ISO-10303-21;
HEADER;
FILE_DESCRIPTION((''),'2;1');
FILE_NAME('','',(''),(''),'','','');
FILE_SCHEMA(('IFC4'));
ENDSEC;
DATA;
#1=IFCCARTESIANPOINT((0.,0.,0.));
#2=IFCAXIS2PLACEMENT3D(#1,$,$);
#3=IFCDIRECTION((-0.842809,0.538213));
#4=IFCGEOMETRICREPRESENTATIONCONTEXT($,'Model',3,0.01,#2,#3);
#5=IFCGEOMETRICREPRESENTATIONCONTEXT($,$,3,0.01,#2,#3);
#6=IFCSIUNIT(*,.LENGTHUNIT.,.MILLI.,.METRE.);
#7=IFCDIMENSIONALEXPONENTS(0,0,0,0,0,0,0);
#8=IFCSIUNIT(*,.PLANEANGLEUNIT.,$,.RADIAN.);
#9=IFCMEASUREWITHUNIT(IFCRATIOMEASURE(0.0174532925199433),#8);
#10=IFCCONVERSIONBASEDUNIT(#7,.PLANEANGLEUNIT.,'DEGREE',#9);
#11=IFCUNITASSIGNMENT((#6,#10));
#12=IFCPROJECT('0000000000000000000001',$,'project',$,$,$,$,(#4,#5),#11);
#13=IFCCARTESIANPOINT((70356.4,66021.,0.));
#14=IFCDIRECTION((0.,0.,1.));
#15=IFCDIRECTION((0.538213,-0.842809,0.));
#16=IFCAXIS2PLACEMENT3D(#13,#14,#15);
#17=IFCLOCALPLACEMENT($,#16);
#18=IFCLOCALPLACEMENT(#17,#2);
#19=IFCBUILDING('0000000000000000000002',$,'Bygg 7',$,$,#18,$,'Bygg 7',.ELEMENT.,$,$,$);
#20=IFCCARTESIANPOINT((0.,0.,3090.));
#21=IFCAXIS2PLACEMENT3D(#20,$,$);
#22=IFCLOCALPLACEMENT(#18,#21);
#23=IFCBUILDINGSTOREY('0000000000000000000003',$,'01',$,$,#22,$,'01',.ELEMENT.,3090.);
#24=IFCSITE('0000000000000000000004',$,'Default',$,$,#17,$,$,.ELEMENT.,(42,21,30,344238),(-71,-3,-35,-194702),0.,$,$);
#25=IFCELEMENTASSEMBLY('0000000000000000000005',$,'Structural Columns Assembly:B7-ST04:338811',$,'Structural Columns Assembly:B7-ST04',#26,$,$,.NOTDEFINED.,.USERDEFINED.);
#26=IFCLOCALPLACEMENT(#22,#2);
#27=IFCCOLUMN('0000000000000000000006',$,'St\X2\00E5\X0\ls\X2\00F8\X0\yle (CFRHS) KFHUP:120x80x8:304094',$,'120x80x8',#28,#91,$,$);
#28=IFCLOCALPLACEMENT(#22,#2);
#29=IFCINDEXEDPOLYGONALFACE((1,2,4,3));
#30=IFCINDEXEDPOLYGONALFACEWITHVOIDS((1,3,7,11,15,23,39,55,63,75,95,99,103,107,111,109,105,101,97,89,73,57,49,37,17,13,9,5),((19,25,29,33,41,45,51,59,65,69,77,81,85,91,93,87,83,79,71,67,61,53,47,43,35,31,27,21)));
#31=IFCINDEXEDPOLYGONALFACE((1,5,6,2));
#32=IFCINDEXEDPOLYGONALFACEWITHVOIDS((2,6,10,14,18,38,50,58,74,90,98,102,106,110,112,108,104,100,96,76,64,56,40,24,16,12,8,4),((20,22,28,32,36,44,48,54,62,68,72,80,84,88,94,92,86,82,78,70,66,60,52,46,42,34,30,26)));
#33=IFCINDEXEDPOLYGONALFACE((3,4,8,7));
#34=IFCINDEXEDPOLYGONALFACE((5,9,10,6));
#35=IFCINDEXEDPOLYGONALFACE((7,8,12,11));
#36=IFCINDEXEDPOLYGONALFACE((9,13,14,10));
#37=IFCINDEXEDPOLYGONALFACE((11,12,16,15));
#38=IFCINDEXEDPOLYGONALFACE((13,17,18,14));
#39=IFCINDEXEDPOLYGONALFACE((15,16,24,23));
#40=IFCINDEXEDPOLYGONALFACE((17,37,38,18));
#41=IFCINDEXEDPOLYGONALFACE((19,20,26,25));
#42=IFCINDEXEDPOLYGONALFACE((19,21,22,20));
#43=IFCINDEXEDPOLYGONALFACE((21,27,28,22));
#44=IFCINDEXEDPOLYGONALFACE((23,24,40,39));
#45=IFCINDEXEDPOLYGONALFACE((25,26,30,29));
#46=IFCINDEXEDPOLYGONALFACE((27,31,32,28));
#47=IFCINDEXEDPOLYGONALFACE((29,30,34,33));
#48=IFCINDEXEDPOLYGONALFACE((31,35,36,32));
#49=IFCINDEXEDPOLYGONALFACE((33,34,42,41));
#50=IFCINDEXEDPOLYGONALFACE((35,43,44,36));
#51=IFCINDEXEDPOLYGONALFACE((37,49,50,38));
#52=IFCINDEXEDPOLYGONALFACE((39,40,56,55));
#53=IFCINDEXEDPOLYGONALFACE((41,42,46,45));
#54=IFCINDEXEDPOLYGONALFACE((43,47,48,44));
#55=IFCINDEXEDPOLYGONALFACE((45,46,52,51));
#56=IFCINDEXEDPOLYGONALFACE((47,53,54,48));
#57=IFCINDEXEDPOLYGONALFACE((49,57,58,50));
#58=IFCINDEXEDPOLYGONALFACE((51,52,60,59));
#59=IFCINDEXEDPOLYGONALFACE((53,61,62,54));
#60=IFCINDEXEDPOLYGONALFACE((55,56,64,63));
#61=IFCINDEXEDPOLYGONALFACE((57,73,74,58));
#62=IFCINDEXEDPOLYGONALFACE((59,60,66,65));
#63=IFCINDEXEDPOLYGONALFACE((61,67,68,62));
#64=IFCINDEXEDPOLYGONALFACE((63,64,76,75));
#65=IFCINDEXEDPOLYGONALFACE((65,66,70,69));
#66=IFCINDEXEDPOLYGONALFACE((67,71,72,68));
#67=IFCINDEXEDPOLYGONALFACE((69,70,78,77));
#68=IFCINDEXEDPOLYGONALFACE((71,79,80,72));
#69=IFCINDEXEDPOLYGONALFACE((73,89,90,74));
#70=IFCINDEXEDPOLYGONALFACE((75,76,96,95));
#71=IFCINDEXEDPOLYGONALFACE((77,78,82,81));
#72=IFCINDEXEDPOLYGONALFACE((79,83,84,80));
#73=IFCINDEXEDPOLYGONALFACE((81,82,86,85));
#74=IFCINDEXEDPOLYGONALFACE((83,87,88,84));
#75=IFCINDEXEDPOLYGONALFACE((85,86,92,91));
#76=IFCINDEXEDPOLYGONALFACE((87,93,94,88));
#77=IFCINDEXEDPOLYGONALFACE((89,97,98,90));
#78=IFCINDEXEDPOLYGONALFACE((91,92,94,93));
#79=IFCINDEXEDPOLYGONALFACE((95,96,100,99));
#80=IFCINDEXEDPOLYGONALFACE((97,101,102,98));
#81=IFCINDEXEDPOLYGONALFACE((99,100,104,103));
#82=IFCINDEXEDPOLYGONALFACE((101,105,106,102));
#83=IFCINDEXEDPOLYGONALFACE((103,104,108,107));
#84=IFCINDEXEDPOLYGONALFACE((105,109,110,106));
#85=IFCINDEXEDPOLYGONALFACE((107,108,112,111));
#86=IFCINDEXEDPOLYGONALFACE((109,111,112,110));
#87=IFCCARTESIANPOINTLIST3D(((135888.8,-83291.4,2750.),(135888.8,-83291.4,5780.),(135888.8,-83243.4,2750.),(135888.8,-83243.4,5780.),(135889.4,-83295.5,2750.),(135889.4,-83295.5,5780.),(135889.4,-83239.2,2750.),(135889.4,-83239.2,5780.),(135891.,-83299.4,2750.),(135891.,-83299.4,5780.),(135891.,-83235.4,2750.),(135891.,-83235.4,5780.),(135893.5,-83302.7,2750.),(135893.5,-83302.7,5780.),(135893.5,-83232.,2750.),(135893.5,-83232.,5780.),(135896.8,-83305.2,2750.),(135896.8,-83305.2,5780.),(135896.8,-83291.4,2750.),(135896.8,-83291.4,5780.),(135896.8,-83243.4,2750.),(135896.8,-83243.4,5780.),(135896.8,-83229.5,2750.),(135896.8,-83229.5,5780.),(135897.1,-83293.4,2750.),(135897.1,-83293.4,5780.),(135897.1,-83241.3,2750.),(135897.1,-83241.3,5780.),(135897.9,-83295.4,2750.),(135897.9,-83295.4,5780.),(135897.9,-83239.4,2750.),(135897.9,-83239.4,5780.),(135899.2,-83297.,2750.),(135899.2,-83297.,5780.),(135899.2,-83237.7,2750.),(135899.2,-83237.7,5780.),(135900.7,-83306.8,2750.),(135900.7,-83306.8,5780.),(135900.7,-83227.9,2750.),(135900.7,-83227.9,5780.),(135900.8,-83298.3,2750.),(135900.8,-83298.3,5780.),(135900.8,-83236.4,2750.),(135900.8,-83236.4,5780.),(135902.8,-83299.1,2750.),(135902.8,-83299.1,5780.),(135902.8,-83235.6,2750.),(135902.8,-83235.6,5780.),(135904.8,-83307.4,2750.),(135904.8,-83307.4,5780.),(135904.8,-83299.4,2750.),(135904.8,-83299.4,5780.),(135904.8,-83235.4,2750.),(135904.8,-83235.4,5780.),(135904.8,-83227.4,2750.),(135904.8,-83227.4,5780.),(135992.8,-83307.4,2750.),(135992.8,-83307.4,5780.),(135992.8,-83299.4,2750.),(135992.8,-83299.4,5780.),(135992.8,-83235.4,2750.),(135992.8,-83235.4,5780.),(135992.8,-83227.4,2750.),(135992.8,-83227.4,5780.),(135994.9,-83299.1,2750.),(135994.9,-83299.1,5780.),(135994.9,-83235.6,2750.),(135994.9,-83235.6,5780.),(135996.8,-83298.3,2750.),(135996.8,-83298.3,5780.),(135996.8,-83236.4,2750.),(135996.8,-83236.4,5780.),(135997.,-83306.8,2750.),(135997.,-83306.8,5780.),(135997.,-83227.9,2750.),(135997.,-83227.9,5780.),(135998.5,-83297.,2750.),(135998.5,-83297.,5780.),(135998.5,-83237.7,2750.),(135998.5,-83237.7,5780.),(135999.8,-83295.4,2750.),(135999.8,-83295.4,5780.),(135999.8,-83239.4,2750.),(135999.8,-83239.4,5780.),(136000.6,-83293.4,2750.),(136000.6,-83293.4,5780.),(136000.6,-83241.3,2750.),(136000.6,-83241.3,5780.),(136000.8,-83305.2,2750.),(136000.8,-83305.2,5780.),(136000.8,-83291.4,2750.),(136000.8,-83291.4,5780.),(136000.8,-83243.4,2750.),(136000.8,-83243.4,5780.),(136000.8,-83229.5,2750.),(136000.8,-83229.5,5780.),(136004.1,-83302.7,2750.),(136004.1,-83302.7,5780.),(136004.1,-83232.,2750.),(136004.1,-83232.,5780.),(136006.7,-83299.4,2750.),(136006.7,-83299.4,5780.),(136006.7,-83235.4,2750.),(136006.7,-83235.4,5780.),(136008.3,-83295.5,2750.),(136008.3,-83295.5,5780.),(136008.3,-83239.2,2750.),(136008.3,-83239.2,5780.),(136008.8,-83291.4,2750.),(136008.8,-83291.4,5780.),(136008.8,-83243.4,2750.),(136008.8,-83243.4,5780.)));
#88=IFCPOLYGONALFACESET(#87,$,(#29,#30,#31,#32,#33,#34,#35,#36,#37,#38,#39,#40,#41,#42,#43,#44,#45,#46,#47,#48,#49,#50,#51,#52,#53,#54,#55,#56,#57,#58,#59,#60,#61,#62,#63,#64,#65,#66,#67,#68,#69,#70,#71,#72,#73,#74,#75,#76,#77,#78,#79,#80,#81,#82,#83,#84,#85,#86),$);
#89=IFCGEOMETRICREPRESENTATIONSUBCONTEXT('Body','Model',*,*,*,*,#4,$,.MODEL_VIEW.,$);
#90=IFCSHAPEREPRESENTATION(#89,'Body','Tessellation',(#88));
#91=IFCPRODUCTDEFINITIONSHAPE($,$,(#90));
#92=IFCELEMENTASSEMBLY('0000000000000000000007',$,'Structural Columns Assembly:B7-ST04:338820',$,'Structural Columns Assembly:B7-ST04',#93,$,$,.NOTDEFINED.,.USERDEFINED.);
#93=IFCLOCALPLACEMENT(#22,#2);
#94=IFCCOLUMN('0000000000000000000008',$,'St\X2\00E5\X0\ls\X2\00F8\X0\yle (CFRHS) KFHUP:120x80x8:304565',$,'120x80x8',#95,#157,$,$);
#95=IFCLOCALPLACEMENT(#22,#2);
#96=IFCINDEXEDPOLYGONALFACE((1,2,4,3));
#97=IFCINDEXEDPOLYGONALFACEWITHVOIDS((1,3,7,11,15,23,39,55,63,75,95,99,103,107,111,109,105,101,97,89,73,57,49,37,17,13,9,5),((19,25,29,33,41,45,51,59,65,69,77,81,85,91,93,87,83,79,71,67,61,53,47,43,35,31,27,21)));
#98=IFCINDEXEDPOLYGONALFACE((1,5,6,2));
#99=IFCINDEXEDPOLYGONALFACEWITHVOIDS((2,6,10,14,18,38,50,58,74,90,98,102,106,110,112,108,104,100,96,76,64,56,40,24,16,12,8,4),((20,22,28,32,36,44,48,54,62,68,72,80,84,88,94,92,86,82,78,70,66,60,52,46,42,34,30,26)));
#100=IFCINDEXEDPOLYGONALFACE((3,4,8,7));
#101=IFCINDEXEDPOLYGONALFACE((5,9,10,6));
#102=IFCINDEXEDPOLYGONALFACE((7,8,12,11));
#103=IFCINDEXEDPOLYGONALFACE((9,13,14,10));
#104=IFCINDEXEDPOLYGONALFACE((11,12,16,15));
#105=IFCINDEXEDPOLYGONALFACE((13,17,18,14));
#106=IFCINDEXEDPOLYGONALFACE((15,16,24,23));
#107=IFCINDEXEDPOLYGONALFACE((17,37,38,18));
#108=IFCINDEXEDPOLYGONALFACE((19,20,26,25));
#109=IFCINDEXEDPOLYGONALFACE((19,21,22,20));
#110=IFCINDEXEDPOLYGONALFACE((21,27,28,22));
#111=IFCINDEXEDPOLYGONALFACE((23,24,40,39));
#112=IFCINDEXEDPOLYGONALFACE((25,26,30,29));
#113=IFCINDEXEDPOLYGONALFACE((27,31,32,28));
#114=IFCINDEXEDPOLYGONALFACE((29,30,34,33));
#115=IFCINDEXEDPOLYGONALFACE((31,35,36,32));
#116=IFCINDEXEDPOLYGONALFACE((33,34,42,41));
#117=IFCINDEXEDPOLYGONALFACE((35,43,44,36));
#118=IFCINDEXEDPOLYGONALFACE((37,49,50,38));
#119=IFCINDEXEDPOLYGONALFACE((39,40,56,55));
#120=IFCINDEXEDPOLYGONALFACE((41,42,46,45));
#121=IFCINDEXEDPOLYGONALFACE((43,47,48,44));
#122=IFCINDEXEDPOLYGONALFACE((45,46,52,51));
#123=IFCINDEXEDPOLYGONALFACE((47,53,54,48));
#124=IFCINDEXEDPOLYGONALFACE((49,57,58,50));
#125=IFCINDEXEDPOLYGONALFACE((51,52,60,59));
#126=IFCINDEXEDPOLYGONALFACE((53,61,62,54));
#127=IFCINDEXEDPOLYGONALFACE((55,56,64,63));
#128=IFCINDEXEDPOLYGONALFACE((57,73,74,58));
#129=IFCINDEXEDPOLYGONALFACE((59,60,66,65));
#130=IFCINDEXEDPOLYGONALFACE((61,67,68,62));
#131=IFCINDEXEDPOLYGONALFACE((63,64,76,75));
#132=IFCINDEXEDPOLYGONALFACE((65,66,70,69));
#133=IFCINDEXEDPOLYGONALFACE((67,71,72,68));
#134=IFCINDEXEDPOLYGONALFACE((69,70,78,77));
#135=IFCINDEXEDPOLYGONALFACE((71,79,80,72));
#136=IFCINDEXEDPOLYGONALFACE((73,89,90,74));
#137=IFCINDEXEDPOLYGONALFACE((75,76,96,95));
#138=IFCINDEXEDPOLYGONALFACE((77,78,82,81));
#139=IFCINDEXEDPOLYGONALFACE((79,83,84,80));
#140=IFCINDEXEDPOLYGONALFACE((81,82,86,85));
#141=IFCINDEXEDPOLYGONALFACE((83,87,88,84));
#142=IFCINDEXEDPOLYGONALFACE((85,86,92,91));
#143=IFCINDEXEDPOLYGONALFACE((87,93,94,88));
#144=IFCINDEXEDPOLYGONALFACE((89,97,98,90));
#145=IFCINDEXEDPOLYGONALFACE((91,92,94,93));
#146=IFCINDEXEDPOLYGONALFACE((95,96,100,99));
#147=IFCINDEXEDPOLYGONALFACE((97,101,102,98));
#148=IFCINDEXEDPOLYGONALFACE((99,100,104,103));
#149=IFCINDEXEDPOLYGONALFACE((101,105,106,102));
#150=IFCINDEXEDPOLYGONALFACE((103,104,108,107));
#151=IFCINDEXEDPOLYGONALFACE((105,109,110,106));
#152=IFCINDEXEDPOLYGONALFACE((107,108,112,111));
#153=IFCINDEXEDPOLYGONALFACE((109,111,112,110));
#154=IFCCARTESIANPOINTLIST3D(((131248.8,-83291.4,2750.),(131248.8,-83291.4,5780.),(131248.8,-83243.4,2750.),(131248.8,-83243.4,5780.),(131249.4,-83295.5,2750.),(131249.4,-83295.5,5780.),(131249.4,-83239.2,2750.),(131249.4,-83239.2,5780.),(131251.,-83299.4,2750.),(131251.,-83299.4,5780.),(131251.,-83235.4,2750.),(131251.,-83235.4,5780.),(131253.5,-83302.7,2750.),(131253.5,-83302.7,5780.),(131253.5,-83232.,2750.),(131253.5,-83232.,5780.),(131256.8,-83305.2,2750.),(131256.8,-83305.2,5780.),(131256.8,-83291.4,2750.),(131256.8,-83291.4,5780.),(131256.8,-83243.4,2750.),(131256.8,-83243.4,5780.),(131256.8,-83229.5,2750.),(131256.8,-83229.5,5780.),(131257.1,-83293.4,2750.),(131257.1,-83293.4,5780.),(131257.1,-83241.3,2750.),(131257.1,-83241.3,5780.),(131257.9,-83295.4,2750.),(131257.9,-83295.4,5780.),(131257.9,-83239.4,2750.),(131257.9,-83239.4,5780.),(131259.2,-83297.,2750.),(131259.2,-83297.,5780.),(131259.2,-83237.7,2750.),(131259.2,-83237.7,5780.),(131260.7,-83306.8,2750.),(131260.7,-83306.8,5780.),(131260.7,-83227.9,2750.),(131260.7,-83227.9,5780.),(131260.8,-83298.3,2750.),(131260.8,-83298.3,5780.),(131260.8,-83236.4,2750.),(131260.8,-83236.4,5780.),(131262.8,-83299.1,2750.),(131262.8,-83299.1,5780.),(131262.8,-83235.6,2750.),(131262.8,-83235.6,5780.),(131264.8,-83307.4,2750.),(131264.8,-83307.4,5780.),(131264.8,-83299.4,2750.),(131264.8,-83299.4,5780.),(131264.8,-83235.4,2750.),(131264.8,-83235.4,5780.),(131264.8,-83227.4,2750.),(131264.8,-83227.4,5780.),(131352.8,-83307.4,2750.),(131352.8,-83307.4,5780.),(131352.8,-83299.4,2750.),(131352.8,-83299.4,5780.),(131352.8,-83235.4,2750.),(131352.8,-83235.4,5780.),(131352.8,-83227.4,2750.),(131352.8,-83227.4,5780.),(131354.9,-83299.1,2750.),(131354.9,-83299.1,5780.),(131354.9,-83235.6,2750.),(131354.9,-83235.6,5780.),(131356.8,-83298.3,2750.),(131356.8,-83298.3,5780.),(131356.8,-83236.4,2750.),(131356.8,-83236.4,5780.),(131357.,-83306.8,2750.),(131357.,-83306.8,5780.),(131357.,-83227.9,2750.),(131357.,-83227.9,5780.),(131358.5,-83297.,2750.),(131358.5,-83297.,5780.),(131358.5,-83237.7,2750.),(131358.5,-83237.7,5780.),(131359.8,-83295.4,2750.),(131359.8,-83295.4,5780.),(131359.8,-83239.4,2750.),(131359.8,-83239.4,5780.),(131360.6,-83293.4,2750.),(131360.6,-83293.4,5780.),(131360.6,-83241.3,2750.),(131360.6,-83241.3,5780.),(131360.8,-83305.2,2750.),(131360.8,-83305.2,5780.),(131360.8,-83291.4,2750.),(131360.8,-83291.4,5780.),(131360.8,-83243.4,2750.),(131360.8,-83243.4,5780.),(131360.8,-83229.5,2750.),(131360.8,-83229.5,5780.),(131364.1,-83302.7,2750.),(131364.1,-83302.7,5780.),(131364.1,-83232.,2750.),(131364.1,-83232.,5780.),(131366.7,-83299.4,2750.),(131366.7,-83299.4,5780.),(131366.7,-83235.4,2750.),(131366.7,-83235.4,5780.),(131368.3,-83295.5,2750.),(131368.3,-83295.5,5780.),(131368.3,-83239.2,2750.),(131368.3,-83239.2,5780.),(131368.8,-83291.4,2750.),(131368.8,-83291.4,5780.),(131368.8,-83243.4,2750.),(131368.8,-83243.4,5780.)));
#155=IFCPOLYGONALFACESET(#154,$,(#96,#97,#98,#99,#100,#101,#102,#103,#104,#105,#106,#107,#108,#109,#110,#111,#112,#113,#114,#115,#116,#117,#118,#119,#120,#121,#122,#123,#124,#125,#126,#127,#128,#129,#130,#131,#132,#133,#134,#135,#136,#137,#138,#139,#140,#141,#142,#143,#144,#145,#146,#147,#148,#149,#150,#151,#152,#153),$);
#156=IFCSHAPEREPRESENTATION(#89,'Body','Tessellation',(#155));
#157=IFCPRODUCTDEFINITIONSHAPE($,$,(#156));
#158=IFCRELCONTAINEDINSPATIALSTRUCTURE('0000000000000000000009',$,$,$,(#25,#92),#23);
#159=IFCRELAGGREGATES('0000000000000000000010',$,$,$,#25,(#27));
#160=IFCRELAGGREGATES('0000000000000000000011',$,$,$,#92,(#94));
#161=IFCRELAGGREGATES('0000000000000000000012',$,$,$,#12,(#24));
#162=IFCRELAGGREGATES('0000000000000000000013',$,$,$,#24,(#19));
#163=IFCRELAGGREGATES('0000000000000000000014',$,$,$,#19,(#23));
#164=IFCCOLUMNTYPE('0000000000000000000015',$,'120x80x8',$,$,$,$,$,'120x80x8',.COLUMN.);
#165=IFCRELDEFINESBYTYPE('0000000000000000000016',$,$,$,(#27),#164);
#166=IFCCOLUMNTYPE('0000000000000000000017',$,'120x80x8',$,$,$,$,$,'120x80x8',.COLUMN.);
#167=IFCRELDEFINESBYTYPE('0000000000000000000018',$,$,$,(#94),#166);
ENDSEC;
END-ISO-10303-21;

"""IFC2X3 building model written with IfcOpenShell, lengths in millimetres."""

from ifc_helpers import new_model, entity, si_unit, converted_unit, direction, frame, frame_2d, origin, place, context, subcontext, project, spatial, polyline, circle_curve, parameter, trimmed, segment, composite_curve, outline, extrude, source, transform, mapped, type_object, type_shapes, element, aggregate, save


model = new_model("IFC2X3")

# Units and contexts
model_context = context("Model", 3, precision=0.01, world=origin(), true_north=direction((-0.842809, 0.538213)))
context_of_model = context(None, 3, precision=0.01, world=origin(), true_north=direction((-0.842809, 0.538213)))
body_context = subcontext(model_context, "Body", "Model", "MODEL_VIEW")
ifc_project = project(units=[si_unit("LENGTHUNIT", "METRE", prefix="MILLI"), converted_unit("PLANEANGLEUNIT", "DEGREE", entity("IfcRatioMeasure", 0.0174532925199433), si_unit("PLANEANGLEUNIT", "RADIAN"), dimensions=[0, 0, 0, 0, 0, 0, 0])], contexts=[model_context, context_of_model])

# Site, building, storey
site_placement = place(None, frame((70356.4, 66021.0, 0.0), z_axis=(0.0, 0.0, 1.0), x_axis=(0.538213, -0.842809, 0.0)))
site = spatial("IfcSite", under=ifc_project, at=site_placement, Name="Default", CompositionType="ELEMENT", RefLatitude=(42, 21, 30, 344238), RefLongitude=(-71, -3, -35, -194702), RefElevation=0.0)
building_placement = place(site_placement, origin())
building = spatial("IfcBuilding", under=site, at=building_placement, Name="Bygg 7", LongName="Bygg 7", CompositionType="ELEMENT")
storey_placement = place(building_placement, frame((0.0, 0.0, 3090.0)))
storey = spatial("IfcBuildingStorey", under=building, at=storey_placement, Name="01", LongName="01", CompositionType="ELEMENT", Elevation=3090.0)

# Element assemblies, columns
assembly_1_placement = place(storey_placement, origin())
assembly_1 = element("IfcElementAssembly", 1, at=assembly_1_placement, inside=storey, Name="Structural Columns Assembly:B7-ST04:338811", ObjectType="Structural Columns Assembly:B7-ST04", AssemblyPlace="NOTDEFINED", PredefinedType="USERDEFINED")
column_type_1 = type_object("IfcColumnType", Name="120x80x8", ElementType="120x80x8", PredefinedType="COLUMN")
shared_shape_1 = source(origin(), body_context, "Body", "SweptSolid", [
    extrude(outline(composite_curve([segment(trimmed(circle_curve(frame_2d((-24.0, 44.0), x_axis=(1.0, 0.0)), 16.0), [parameter(90.0)], [parameter(180.0)], True, "PARAMETER"), True, "CONTINUOUS"), segment(polyline([(-40.0, 44.0), (-40.0, -44.0)]), True, "CONTINUOUS"), segment(trimmed(circle_curve(frame_2d((-24.0, -44.0), x_axis=(1.0, 0.0)), 16.0), [parameter(180.0)], [parameter(270.0)], True, "PARAMETER"), True, "CONTINUOUS"), segment(polyline([(-24.0, -60.0), (24.0, -60.0)]), True, "CONTINUOUS"), segment(trimmed(circle_curve(frame_2d((24.0, -44.0), x_axis=(1.0, 0.0)), 16.0), [parameter(270.0)], [parameter(0.0)], True, "PARAMETER"), True, "CONTINUOUS"), segment(polyline([(40.0, -44.0), (40.0, 44.0)]), True, "CONTINUOUS"), segment(trimmed(circle_curve(frame_2d((24.0, 44.0), x_axis=(1.0, 0.0)), 16.0), [parameter(0.0)], [parameter(90.0)], True, "PARAMETER"), True, "CONTINUOUS"), segment(polyline([(24.0, 60.0), (-24.0, 60.0)]), True, "CONTINUOUS")], self_intersect=False), holes=[composite_curve([segment(polyline([(-24.0, 52.0), (24.0, 52.0)]), True, "CONTINUOUS"), segment(trimmed(circle_curve(frame_2d((24.0, 44.0), x_axis=(1.0, 0.0)), 8.0), [parameter(360.0)], [parameter(90.0)], True, "PARAMETER"), False, "CONTINUOUS"), segment(polyline([(32.0, 44.0), (32.0, -44.0)]), True, "CONTINUOUS"), segment(trimmed(circle_curve(frame_2d((24.0, -44.0), x_axis=(1.0, 0.0)), 8.0), [parameter(270.0)], [parameter(360.0)], True, "PARAMETER"), False, "CONTINUOUS"), segment(polyline([(24.0, -52.0), (-24.0, -52.0)]), True, "CONTINUOUS"), segment(trimmed(circle_curve(frame_2d((-24.0, -44.0), x_axis=(1.0, 0.0)), 8.0), [parameter(180.0)], [parameter(270.0)], True, "PARAMETER"), False, "CONTINUOUS"), segment(polyline([(-32.0, -44.0), (-32.0, 44.0)]), True, "CONTINUOUS"), segment(trimmed(circle_curve(frame_2d((-24.0, 44.0), x_axis=(1.0, 0.0)), 8.0), [parameter(90.0)], [parameter(180.0)], True, "PARAMETER"), False, "CONTINUOUS")], self_intersect=False)]), frame((61.6, 41.6, 0.0), z_axis=(0.0, 0.0, 1.0), x_axis=(0.0, -1.0, 0.0)), (0.0, 0.0, 1.0), 3030.0),
])
type_shapes(column_type_1, [shared_shape_1])
column_1_placement = place(assembly_1_placement, frame((135887.2, -83309.0, 2750.0)))
column_1 = element("IfcColumn", 2, at=column_1_placement, type_object=column_type_1, Name="Stålsøyle (CFRHS) KFHUP:120x80x8:304094", ObjectType="120x80x8", context=body_context, shape_type="MappedRepresentation", body=[
    mapped(shared_shape_1, transform((0.0, 0.0, 0.0), scale=1.0)),
])
aggregate(assembly_1, [column_1])
assembly_2_placement = place(storey_placement, origin())
assembly_2 = element("IfcElementAssembly", 3, at=assembly_2_placement, inside=storey, Name="Structural Columns Assembly:B7-ST04:338820", ObjectType="Structural Columns Assembly:B7-ST04", AssemblyPlace="NOTDEFINED", PredefinedType="USERDEFINED")
column_type_2 = type_object("IfcColumnType", Name="120x80x8", ElementType="120x80x8", PredefinedType="COLUMN")
shared_shape_2 = source(origin(), body_context, "Body", "SweptSolid", [
    extrude(outline(composite_curve([segment(trimmed(circle_curve(frame_2d((-24.0, 44.0), x_axis=(1.0, 0.0)), 16.0), [parameter(90.0)], [parameter(180.0)], True, "PARAMETER"), True, "CONTINUOUS"), segment(polyline([(-40.0, 44.0), (-40.0, -44.0)]), True, "CONTINUOUS"), segment(trimmed(circle_curve(frame_2d((-24.0, -44.0), x_axis=(1.0, 0.0)), 16.0), [parameter(180.0)], [parameter(270.0)], True, "PARAMETER"), True, "CONTINUOUS"), segment(polyline([(-24.0, -60.0), (24.0, -60.0)]), True, "CONTINUOUS"), segment(trimmed(circle_curve(frame_2d((24.0, -44.0), x_axis=(1.0, 0.0)), 16.0), [parameter(270.0)], [parameter(0.0)], True, "PARAMETER"), True, "CONTINUOUS"), segment(polyline([(40.0, -44.0), (40.0, 44.0)]), True, "CONTINUOUS"), segment(trimmed(circle_curve(frame_2d((24.0, 44.0), x_axis=(1.0, 0.0)), 16.0), [parameter(0.0)], [parameter(90.0)], True, "PARAMETER"), True, "CONTINUOUS"), segment(polyline([(24.0, 60.0), (-24.0, 60.0)]), True, "CONTINUOUS")], self_intersect=False), holes=[composite_curve([segment(polyline([(-24.0, 52.0), (24.0, 52.0)]), True, "CONTINUOUS"), segment(trimmed(circle_curve(frame_2d((24.0, 44.0), x_axis=(1.0, 0.0)), 8.0), [parameter(360.0)], [parameter(90.0)], True, "PARAMETER"), False, "CONTINUOUS"), segment(polyline([(32.0, 44.0), (32.0, -44.0)]), True, "CONTINUOUS"), segment(trimmed(circle_curve(frame_2d((24.0, -44.0), x_axis=(1.0, 0.0)), 8.0), [parameter(270.0)], [parameter(360.0)], True, "PARAMETER"), False, "CONTINUOUS"), segment(polyline([(24.0, -52.0), (-24.0, -52.0)]), True, "CONTINUOUS"), segment(trimmed(circle_curve(frame_2d((-24.0, -44.0), x_axis=(1.0, 0.0)), 8.0), [parameter(180.0)], [parameter(270.0)], True, "PARAMETER"), False, "CONTINUOUS"), segment(polyline([(-32.0, -44.0), (-32.0, 44.0)]), True, "CONTINUOUS"), segment(trimmed(circle_curve(frame_2d((-24.0, 44.0), x_axis=(1.0, 0.0)), 8.0), [parameter(90.0)], [parameter(180.0)], True, "PARAMETER"), False, "CONTINUOUS")], self_intersect=False)]), frame((61.6, 41.6, 0.0), z_axis=(0.0, 0.0, 1.0), x_axis=(0.0, -1.0, 0.0)), (0.0, 0.0, 1.0), 3030.0),
])
type_shapes(column_type_2, [shared_shape_2])
column_2_placement = place(assembly_2_placement, frame((131247.2, -83309.0, 2750.0)))
column_2 = element("IfcColumn", 4, at=column_2_placement, type_object=column_type_2, Name="Stålsøyle (CFRHS) KFHUP:120x80x8:304565", ObjectType="120x80x8", context=body_context, shape_type="MappedRepresentation", body=[
    mapped(shared_shape_2, transform((0.0, 0.0, 0.0), scale=1.0)),
])
aggregate(assembly_2, [column_2])

save(model, "model.ifc")
